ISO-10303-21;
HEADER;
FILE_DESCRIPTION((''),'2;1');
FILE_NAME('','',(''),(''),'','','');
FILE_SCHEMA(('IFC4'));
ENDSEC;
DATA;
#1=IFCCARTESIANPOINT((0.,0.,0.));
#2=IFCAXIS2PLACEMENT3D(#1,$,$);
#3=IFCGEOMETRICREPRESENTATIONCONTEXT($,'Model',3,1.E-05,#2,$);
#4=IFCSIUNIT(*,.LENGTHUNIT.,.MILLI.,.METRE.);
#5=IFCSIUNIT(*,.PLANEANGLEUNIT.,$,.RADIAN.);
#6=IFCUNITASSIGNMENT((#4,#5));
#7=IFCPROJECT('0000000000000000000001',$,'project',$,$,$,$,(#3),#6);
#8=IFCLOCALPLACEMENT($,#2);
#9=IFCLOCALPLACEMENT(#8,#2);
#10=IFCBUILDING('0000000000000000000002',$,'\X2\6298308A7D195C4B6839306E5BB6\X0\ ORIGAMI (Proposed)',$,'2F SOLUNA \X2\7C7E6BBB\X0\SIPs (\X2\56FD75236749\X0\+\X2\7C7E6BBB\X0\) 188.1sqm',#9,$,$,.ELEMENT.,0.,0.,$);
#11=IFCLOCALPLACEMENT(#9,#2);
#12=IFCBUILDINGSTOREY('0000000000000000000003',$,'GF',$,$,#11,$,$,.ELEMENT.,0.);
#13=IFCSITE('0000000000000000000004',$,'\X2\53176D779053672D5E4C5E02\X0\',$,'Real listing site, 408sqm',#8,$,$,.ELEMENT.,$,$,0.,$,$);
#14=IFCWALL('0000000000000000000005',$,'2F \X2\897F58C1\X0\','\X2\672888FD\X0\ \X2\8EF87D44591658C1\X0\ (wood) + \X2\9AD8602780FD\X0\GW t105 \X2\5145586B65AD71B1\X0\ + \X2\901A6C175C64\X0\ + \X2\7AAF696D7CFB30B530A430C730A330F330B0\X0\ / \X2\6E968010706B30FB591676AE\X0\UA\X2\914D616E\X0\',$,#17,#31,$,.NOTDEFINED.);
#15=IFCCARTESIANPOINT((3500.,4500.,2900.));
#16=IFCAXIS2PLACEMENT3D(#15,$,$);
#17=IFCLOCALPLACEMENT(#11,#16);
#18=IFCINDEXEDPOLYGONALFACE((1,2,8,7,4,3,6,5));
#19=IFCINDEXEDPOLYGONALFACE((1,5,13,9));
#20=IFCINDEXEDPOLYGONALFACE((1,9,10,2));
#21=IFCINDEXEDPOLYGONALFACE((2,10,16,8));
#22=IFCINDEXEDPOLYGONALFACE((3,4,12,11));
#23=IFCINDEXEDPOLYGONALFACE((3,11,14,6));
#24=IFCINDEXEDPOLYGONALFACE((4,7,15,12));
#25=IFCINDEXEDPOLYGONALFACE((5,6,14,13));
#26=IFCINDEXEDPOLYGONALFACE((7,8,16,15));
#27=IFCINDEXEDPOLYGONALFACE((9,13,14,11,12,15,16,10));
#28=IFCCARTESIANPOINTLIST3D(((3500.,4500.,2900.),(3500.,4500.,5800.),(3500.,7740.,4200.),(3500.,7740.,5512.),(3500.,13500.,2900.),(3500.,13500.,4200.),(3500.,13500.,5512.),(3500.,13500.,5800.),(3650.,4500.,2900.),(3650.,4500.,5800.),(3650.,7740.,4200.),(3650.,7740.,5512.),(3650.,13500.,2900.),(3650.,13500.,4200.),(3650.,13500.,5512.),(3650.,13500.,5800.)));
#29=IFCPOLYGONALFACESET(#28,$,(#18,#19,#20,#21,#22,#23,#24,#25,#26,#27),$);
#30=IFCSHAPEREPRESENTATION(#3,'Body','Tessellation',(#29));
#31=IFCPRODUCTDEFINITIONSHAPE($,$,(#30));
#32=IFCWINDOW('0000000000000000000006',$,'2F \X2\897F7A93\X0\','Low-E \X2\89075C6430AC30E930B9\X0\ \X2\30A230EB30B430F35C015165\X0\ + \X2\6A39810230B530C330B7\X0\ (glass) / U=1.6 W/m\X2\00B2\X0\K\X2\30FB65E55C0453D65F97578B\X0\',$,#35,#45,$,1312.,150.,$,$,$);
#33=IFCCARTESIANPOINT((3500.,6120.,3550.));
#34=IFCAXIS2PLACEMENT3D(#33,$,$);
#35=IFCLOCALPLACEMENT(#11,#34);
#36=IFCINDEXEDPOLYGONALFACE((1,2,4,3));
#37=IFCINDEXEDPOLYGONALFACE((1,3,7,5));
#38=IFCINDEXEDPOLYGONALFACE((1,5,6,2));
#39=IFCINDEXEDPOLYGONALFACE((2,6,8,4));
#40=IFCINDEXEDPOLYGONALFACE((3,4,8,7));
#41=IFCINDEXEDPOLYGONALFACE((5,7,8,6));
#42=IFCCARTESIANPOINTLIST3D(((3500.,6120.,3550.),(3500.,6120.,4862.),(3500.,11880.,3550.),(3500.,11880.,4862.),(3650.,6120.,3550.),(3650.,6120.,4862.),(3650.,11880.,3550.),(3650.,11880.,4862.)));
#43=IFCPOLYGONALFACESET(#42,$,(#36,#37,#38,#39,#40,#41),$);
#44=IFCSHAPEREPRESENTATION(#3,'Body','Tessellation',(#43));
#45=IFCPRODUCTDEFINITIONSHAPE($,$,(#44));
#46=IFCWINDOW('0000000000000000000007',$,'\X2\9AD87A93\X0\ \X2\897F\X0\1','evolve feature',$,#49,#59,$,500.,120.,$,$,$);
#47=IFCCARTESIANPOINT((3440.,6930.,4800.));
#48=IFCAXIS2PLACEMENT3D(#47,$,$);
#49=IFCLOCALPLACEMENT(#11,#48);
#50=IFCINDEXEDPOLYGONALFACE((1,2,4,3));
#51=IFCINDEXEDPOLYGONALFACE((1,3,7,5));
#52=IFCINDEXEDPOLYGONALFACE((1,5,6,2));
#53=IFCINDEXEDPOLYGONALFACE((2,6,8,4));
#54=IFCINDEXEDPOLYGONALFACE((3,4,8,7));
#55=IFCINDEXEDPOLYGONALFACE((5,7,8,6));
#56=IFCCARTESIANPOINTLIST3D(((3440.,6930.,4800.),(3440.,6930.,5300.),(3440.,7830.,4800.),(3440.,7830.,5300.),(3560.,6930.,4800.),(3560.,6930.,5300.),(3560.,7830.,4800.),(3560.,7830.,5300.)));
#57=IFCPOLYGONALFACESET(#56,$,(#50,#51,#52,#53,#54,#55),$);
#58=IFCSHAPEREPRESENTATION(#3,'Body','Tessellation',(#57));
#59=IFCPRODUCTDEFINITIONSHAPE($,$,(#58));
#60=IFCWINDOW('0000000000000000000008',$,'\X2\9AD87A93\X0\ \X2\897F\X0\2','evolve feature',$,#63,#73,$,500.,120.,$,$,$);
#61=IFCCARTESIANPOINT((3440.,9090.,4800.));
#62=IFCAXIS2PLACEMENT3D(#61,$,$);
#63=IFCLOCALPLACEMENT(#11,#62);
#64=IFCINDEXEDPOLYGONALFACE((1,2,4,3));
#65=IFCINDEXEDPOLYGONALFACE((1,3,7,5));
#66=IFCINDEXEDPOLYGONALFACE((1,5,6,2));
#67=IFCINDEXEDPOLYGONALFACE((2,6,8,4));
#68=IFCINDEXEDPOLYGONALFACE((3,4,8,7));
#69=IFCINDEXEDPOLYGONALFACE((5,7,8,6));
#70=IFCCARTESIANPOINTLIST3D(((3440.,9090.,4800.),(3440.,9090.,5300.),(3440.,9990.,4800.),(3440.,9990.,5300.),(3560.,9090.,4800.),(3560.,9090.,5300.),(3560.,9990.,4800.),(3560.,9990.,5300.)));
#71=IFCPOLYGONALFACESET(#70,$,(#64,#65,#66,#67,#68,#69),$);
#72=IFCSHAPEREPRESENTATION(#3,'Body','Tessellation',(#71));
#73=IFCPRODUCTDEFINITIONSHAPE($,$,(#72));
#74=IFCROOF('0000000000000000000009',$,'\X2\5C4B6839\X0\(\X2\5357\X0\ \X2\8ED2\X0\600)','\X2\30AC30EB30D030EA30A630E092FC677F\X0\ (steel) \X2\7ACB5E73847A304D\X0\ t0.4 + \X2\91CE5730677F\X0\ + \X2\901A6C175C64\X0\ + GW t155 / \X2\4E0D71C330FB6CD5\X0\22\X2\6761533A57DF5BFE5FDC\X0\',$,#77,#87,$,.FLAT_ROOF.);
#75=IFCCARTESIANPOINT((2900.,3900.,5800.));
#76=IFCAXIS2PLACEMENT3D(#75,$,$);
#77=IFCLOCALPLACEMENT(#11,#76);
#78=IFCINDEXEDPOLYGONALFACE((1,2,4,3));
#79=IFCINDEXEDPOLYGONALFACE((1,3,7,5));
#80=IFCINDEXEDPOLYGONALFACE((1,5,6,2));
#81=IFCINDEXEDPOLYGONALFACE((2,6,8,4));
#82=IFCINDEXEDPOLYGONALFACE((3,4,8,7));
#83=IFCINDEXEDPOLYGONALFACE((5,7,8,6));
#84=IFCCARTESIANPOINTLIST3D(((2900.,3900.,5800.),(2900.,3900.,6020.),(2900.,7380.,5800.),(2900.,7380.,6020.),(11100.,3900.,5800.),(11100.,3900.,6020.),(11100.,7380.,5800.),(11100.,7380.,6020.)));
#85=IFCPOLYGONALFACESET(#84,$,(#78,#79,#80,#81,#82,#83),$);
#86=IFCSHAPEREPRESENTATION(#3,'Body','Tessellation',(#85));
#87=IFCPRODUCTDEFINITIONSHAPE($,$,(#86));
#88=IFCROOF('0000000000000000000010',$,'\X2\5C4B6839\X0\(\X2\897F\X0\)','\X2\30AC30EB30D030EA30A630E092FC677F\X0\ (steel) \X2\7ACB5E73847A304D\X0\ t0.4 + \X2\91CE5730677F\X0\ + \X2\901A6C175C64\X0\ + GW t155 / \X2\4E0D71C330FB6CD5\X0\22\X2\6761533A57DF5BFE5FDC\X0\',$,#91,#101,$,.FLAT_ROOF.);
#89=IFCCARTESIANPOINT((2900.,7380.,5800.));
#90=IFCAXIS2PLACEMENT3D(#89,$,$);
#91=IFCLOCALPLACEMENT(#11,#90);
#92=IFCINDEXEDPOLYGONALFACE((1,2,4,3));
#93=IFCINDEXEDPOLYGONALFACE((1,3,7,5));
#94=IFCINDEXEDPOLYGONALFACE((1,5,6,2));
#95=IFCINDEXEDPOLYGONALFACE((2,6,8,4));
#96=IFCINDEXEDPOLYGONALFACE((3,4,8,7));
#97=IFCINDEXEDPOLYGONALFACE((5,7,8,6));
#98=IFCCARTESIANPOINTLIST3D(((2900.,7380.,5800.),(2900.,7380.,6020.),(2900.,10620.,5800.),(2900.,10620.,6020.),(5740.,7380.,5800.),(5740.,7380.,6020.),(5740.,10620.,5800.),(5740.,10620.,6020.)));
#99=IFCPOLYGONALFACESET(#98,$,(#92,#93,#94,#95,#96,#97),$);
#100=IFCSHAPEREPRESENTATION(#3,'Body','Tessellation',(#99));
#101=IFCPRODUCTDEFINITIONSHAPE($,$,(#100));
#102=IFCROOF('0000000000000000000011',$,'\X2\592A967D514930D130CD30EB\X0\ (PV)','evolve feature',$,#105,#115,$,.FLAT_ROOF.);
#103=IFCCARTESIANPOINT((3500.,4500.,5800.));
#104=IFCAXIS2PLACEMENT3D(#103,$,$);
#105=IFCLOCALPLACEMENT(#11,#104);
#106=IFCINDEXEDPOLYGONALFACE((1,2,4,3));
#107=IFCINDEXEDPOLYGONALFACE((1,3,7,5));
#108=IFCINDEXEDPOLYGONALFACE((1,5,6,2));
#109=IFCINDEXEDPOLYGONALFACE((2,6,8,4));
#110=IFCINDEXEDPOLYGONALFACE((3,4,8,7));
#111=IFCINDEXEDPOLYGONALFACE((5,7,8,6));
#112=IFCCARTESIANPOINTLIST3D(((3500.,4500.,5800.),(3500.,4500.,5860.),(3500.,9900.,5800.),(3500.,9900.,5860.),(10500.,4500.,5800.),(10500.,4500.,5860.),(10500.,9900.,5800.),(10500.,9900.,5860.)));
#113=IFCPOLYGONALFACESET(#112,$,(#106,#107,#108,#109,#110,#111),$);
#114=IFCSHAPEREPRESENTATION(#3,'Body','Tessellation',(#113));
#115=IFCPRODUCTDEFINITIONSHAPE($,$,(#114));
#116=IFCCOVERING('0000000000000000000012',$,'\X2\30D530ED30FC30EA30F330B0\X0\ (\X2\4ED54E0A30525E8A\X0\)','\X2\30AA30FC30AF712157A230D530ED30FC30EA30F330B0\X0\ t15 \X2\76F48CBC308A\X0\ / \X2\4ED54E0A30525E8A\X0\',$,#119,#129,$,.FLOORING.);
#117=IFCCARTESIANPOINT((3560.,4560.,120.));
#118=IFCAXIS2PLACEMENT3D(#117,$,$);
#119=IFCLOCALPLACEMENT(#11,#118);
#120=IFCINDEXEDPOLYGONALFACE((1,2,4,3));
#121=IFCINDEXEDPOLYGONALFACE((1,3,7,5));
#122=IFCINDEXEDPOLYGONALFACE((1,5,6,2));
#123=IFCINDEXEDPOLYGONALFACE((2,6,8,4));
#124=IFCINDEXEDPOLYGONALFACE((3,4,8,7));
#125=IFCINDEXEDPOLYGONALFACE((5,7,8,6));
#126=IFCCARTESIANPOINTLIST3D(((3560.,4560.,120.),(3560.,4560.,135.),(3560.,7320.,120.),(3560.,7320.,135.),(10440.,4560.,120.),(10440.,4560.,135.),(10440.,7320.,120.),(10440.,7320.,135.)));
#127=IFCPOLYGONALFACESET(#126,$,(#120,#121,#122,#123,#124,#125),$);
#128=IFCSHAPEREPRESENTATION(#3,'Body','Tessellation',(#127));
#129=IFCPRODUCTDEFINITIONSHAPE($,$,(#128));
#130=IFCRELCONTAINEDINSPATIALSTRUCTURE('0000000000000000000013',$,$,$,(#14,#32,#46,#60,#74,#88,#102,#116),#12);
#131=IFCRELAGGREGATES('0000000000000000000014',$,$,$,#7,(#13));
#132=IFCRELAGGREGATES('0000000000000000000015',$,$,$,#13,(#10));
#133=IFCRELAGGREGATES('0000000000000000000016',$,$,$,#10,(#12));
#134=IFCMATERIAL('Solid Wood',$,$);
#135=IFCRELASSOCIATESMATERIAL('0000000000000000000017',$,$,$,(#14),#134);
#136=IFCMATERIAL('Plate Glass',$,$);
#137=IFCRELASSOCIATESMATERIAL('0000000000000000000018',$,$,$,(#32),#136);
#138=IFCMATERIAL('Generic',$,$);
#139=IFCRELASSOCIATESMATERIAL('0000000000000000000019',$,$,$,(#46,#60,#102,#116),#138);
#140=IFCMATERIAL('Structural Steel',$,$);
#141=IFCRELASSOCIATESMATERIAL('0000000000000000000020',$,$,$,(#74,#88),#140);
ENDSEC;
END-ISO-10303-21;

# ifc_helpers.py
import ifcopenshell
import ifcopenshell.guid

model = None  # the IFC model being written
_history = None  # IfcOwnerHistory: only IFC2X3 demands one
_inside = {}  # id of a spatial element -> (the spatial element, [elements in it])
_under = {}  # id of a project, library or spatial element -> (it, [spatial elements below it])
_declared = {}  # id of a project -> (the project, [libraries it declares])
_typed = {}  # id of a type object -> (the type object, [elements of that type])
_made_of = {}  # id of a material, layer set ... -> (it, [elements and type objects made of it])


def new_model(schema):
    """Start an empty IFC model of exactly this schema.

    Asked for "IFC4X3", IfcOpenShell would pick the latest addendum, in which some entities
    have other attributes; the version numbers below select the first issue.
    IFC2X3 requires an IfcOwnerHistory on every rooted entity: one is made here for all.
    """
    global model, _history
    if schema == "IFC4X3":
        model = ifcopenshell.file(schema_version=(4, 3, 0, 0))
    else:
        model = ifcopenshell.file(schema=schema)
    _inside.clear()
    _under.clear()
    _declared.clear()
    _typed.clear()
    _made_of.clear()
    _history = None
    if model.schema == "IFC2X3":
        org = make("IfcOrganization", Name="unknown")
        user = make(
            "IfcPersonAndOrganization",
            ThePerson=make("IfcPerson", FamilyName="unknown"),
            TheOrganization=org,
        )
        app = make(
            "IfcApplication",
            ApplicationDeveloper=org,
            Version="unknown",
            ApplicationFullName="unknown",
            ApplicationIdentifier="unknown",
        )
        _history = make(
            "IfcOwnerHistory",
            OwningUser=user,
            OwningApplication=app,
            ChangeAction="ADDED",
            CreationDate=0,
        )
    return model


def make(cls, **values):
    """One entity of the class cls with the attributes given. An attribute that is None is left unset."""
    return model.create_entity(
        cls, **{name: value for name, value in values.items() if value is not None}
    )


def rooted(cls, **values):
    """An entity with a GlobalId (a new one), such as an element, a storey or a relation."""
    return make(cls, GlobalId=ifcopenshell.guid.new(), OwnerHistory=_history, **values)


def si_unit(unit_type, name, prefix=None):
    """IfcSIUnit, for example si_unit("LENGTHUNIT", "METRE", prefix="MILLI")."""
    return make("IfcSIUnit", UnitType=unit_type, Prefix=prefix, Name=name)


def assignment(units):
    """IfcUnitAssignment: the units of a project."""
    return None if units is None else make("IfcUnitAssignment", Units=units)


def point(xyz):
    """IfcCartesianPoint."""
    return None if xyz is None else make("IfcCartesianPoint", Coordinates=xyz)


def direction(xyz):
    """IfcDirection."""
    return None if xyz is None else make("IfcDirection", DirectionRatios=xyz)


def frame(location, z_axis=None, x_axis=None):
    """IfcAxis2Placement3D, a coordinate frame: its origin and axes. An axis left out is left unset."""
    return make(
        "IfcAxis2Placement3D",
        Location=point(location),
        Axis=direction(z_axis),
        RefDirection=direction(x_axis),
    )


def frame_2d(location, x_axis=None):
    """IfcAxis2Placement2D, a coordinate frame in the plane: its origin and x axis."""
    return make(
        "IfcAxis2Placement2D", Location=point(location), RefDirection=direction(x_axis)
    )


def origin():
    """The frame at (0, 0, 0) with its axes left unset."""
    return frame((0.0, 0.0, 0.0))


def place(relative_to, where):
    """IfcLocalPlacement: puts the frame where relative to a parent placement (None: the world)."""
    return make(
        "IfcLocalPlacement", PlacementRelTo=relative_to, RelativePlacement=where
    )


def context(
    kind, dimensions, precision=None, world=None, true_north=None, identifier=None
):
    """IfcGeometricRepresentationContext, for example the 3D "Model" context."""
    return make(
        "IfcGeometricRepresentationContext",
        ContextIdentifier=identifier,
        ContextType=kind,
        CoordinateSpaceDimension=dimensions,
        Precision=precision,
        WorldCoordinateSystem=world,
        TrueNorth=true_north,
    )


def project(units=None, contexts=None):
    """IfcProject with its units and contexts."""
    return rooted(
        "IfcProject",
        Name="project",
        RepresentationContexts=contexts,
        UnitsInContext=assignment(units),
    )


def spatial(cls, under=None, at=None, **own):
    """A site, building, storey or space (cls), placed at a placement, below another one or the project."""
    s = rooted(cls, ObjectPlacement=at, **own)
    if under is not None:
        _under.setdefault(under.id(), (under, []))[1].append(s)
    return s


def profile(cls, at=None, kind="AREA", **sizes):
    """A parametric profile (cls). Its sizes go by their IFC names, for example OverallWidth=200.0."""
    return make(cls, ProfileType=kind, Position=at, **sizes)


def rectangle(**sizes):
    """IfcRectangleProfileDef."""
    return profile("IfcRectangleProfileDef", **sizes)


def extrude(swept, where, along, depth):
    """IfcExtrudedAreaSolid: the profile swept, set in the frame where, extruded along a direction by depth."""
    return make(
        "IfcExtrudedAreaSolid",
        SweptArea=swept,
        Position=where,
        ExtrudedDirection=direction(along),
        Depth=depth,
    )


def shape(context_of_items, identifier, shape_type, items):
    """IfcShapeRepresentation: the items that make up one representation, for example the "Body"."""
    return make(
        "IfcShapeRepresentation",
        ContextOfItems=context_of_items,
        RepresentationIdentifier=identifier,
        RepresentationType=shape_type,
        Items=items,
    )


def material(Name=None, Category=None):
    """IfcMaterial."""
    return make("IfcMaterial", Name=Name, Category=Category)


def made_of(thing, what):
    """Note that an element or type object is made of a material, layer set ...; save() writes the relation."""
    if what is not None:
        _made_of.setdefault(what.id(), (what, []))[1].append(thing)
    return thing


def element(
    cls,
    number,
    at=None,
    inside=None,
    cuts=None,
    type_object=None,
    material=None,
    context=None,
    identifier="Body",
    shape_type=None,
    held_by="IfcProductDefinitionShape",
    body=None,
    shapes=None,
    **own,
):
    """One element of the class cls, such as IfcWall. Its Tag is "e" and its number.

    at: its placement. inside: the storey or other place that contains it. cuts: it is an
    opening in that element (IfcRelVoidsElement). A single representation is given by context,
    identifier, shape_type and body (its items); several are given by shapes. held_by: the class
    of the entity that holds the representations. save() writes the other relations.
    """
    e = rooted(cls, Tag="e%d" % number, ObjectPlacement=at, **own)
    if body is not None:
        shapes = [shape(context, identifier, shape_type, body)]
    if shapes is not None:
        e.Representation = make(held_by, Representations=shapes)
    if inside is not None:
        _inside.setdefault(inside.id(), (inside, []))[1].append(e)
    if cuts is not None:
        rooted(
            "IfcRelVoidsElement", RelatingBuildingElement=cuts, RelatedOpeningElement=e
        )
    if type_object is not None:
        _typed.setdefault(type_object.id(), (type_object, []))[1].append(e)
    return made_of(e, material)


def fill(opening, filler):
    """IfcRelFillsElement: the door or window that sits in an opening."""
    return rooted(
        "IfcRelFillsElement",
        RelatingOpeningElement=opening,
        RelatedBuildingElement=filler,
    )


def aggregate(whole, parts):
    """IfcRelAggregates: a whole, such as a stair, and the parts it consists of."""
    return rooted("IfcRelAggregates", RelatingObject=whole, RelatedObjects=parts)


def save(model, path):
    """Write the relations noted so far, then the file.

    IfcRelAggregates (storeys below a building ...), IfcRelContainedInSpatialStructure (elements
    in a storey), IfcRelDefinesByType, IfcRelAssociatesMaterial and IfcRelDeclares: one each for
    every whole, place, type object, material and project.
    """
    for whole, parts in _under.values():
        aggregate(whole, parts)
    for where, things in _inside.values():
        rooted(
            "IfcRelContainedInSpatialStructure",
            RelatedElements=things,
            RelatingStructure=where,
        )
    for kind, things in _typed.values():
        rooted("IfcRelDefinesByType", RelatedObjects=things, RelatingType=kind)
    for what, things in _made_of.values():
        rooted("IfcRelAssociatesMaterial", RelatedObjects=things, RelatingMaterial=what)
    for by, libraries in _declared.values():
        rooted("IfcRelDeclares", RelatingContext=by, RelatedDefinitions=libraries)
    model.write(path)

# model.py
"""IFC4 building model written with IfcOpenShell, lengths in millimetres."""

from ifc_helpers import new_model, si_unit, frame, frame_2d, origin, place, context, project, spatial, rectangle, extrude, material, element, fill, save


model = new_model("IFC4")

# Units and contexts
model_context = context("Model", 3, precision=1e-05, world=origin())
ifc_project = project(units=[si_unit("LENGTHUNIT", "METRE", prefix="MILLI"), si_unit("PLANEANGLEUNIT", "RADIAN")], contexts=[model_context])

# Site, building, storey
site_placement = place(None, origin())
site = spatial("IfcSite", under=ifc_project, at=site_placement, Name="北海道札幌市", ObjectType="Real listing site, 408sqm", CompositionType="ELEMENT", RefElevation=0.0)
building_placement = place(site_placement, origin())
building = spatial("IfcBuilding", under=site, at=building_placement, Name="折り紙屋根の家 ORIGAMI (Proposed)", ObjectType="2F SOLUNA 籾殻SIPs (国産杉+籾殻) 188.1sqm", CompositionType="ELEMENT", ElevationOfRefHeight=0.0, ElevationOfTerrain=0.0)
storey_placement = place(building_placement, origin())
storey = spatial("IfcBuildingStorey", under=building, at=storey_placement, Name="GF", CompositionType="ELEMENT", Elevation=0.0)

# Shared definitions
ifc_material_1 = material(Name="Solid Wood")
ifc_material_2 = material(Name="Generic")

# Shared definitions
ifc_material_3 = material(Name="Plate Glass")

# Wall, openings, windows
wall_1_placement = place(storey_placement, frame((3500.0, 4500.0, 2900.0)))
wall_1 = element("IfcWall", 1, at=wall_1_placement, inside=storey, material=ifc_material_1, Name="2F 西壁", Description="木製 軸組外壁 (wood) + 高性能GW t105 充填断熱 + 通気層 + 窯業系サイディング / 準耐火・外皮UA配慮", PredefinedType="NOTDEFINED", context=model_context, shape_type="SweptSolid", body=[
    extrude(rectangle(XDim=150.0, YDim=9000.0, at=frame_2d((75.0, 4500.0))), frame((3500.0, 4500.0, 2900.0)), (0.0, 0.0, 1.0), 2900.0),
])
opening_1_placement = place(storey_placement, frame((3500.0, 6120.0, 3550.0)))
opening_1 = element("IfcOpeningElement", 2, at=opening_1_placement, cuts=wall_1, PredefinedType="NOTDEFINED", context=model_context, shape_type="SweptSolid", body=[
    extrude(rectangle(XDim=150.0, YDim=5760.0, at=frame_2d((75.0, 2880.0))), frame((3500.0, 6120.0, 3550.0)), (0.0, 0.0, 1.0), 1312.0),
])
opening_2_placement = place(storey_placement, frame((3440.0, 6930.0, 4800.0)))
opening_2 = element("IfcOpeningElement", 3, at=opening_2_placement, cuts=wall_1, PredefinedType="NOTDEFINED", context=model_context, shape_type="SweptSolid", body=[
    extrude(rectangle(XDim=120.0, YDim=900.0, at=frame_2d((60.0, 450.0))), frame((3440.0, 6930.0, 4800.0)), (0.0, 0.0, 1.0), 500.0),
])
opening_3_placement = place(storey_placement, frame((3440.0, 9090.0, 4800.0)))
opening_3 = element("IfcOpeningElement", 4, at=opening_3_placement, cuts=wall_1, PredefinedType="NOTDEFINED", context=model_context, shape_type="SweptSolid", body=[
    extrude(rectangle(XDim=120.0, YDim=900.0, at=frame_2d((60.0, 450.0))), frame((3440.0, 9090.0, 4800.0)), (0.0, 0.0, 1.0), 500.0),
])
window_1_placement = place(storey_placement, frame((3500.0, 6120.0, 3550.0)))
window_1 = element("IfcWindow", 5, at=window_1_placement, inside=storey, material=ifc_material_3, Name="2F 西窓", Description="Low-E 複層ガラス アルゴン封入 + 樹脂サッシ (glass) / U=1.6 W/m²K・日射取得型", OverallHeight=1312.0, OverallWidth=150.0, context=model_context, shape_type="SweptSolid", body=[
    extrude(rectangle(XDim=150.0, YDim=5760.0, at=frame_2d((75.0, 2880.0))), frame((3500.0, 6120.0, 3550.0)), (0.0, 0.0, 1.0), 1312.0),
])
fill(opening_1, window_1)
window_2_placement = place(storey_placement, frame((3440.0, 6930.0, 4800.0)))
window_2 = element("IfcWindow", 6, at=window_2_placement, inside=storey, material=ifc_material_2, Name="高窓 西1", Description="evolve feature", OverallHeight=500.0, OverallWidth=120.0, context=model_context, shape_type="SweptSolid", body=[
    extrude(rectangle(XDim=120.0, YDim=900.0, at=frame_2d((60.0, 450.0))), frame((3440.0, 6930.0, 4800.0)), (0.0, 0.0, 1.0), 500.0),
])
fill(opening_2, window_2)
window_3_placement = place(storey_placement, frame((3440.0, 9090.0, 4800.0)))
window_3 = element("IfcWindow", 7, at=window_3_placement, inside=storey, material=ifc_material_2, Name="高窓 西2", Description="evolve feature", OverallHeight=500.0, OverallWidth=120.0, context=model_context, shape_type="SweptSolid", body=[
    extrude(rectangle(XDim=120.0, YDim=900.0, at=frame_2d((60.0, 450.0))), frame((3440.0, 9090.0, 4800.0)), (0.0, 0.0, 1.0), 500.0),
])
fill(opening_3, window_3)

# Roofs
ifc_material_4 = material(Name="Structural Steel")
roof_1_placement = place(storey_placement, frame((2900.0, 3900.0, 5800.0)))
element("IfcRoof", 8, at=roof_1_placement, inside=storey, material=ifc_material_4, Name="屋根(南 軒600)", Description="ガルバリウム鋼板 (steel) 立平葺き t0.4 + 野地板 + 通気層 + GW t155 / 不燃・法22条区域対応", PredefinedType="FLAT_ROOF", context=model_context, shape_type="SweptSolid", body=[
    extrude(rectangle(XDim=8200.0, YDim=3480.0, at=frame_2d((4100.0, 1740.0))), frame((2900.0, 3900.0, 5800.0)), (0.0, 0.0, 1.0), 220.0),
])
roof_2_placement = place(storey_placement, frame((2900.0, 7380.0, 5800.0)))
element("IfcRoof", 9, at=roof_2_placement, inside=storey, material=ifc_material_4, Name="屋根(西)", Description="ガルバリウム鋼板 (steel) 立平葺き t0.4 + 野地板 + 通気層 + GW t155 / 不燃・法22条区域対応", PredefinedType="FLAT_ROOF", context=model_context, shape_type="SweptSolid", body=[
    extrude(rectangle(XDim=2840.0, YDim=3240.0, at=frame_2d((1420.0, 1620.0))), frame((2900.0, 7380.0, 5800.0)), (0.0, 0.0, 1.0), 220.0),
])
roof_3_placement = place(storey_placement, frame((3500.0, 4500.0, 5800.0)))
element("IfcRoof", 10, at=roof_3_placement, inside=storey, material=ifc_material_2, Name="太陽光パネル (PV)", Description="evolve feature", PredefinedType="FLAT_ROOF", context=model_context, shape_type="SweptSolid", body=[
    extrude(rectangle(XDim=7000.0, YDim=5400.0, at=frame_2d((3500.0, 2700.0))), frame((3500.0, 4500.0, 5800.0)), (0.0, 0.0, 1.0), 60.0),
])

# Covering
covering_placement = place(storey_placement, frame((3560.0, 4560.0, 120.0)))
element("IfcCovering", 11, at=covering_placement, inside=storey, material=ifc_material_2, Name="フローリング (仕上げ床)", Description="オーク無垢フローリング t15 直貼り / 仕上げ床", PredefinedType="FLOORING", context=model_context, shape_type="SweptSolid", body=[
    extrude(rectangle(XDim=6880.0, YDim=2760.0, at=frame_2d((3440.0, 1380.0))), frame((3560.0, 4560.0, 120.0)), (0.0, 0.0, 1.0), 15.0),
])

save(model, "model.ifc")
